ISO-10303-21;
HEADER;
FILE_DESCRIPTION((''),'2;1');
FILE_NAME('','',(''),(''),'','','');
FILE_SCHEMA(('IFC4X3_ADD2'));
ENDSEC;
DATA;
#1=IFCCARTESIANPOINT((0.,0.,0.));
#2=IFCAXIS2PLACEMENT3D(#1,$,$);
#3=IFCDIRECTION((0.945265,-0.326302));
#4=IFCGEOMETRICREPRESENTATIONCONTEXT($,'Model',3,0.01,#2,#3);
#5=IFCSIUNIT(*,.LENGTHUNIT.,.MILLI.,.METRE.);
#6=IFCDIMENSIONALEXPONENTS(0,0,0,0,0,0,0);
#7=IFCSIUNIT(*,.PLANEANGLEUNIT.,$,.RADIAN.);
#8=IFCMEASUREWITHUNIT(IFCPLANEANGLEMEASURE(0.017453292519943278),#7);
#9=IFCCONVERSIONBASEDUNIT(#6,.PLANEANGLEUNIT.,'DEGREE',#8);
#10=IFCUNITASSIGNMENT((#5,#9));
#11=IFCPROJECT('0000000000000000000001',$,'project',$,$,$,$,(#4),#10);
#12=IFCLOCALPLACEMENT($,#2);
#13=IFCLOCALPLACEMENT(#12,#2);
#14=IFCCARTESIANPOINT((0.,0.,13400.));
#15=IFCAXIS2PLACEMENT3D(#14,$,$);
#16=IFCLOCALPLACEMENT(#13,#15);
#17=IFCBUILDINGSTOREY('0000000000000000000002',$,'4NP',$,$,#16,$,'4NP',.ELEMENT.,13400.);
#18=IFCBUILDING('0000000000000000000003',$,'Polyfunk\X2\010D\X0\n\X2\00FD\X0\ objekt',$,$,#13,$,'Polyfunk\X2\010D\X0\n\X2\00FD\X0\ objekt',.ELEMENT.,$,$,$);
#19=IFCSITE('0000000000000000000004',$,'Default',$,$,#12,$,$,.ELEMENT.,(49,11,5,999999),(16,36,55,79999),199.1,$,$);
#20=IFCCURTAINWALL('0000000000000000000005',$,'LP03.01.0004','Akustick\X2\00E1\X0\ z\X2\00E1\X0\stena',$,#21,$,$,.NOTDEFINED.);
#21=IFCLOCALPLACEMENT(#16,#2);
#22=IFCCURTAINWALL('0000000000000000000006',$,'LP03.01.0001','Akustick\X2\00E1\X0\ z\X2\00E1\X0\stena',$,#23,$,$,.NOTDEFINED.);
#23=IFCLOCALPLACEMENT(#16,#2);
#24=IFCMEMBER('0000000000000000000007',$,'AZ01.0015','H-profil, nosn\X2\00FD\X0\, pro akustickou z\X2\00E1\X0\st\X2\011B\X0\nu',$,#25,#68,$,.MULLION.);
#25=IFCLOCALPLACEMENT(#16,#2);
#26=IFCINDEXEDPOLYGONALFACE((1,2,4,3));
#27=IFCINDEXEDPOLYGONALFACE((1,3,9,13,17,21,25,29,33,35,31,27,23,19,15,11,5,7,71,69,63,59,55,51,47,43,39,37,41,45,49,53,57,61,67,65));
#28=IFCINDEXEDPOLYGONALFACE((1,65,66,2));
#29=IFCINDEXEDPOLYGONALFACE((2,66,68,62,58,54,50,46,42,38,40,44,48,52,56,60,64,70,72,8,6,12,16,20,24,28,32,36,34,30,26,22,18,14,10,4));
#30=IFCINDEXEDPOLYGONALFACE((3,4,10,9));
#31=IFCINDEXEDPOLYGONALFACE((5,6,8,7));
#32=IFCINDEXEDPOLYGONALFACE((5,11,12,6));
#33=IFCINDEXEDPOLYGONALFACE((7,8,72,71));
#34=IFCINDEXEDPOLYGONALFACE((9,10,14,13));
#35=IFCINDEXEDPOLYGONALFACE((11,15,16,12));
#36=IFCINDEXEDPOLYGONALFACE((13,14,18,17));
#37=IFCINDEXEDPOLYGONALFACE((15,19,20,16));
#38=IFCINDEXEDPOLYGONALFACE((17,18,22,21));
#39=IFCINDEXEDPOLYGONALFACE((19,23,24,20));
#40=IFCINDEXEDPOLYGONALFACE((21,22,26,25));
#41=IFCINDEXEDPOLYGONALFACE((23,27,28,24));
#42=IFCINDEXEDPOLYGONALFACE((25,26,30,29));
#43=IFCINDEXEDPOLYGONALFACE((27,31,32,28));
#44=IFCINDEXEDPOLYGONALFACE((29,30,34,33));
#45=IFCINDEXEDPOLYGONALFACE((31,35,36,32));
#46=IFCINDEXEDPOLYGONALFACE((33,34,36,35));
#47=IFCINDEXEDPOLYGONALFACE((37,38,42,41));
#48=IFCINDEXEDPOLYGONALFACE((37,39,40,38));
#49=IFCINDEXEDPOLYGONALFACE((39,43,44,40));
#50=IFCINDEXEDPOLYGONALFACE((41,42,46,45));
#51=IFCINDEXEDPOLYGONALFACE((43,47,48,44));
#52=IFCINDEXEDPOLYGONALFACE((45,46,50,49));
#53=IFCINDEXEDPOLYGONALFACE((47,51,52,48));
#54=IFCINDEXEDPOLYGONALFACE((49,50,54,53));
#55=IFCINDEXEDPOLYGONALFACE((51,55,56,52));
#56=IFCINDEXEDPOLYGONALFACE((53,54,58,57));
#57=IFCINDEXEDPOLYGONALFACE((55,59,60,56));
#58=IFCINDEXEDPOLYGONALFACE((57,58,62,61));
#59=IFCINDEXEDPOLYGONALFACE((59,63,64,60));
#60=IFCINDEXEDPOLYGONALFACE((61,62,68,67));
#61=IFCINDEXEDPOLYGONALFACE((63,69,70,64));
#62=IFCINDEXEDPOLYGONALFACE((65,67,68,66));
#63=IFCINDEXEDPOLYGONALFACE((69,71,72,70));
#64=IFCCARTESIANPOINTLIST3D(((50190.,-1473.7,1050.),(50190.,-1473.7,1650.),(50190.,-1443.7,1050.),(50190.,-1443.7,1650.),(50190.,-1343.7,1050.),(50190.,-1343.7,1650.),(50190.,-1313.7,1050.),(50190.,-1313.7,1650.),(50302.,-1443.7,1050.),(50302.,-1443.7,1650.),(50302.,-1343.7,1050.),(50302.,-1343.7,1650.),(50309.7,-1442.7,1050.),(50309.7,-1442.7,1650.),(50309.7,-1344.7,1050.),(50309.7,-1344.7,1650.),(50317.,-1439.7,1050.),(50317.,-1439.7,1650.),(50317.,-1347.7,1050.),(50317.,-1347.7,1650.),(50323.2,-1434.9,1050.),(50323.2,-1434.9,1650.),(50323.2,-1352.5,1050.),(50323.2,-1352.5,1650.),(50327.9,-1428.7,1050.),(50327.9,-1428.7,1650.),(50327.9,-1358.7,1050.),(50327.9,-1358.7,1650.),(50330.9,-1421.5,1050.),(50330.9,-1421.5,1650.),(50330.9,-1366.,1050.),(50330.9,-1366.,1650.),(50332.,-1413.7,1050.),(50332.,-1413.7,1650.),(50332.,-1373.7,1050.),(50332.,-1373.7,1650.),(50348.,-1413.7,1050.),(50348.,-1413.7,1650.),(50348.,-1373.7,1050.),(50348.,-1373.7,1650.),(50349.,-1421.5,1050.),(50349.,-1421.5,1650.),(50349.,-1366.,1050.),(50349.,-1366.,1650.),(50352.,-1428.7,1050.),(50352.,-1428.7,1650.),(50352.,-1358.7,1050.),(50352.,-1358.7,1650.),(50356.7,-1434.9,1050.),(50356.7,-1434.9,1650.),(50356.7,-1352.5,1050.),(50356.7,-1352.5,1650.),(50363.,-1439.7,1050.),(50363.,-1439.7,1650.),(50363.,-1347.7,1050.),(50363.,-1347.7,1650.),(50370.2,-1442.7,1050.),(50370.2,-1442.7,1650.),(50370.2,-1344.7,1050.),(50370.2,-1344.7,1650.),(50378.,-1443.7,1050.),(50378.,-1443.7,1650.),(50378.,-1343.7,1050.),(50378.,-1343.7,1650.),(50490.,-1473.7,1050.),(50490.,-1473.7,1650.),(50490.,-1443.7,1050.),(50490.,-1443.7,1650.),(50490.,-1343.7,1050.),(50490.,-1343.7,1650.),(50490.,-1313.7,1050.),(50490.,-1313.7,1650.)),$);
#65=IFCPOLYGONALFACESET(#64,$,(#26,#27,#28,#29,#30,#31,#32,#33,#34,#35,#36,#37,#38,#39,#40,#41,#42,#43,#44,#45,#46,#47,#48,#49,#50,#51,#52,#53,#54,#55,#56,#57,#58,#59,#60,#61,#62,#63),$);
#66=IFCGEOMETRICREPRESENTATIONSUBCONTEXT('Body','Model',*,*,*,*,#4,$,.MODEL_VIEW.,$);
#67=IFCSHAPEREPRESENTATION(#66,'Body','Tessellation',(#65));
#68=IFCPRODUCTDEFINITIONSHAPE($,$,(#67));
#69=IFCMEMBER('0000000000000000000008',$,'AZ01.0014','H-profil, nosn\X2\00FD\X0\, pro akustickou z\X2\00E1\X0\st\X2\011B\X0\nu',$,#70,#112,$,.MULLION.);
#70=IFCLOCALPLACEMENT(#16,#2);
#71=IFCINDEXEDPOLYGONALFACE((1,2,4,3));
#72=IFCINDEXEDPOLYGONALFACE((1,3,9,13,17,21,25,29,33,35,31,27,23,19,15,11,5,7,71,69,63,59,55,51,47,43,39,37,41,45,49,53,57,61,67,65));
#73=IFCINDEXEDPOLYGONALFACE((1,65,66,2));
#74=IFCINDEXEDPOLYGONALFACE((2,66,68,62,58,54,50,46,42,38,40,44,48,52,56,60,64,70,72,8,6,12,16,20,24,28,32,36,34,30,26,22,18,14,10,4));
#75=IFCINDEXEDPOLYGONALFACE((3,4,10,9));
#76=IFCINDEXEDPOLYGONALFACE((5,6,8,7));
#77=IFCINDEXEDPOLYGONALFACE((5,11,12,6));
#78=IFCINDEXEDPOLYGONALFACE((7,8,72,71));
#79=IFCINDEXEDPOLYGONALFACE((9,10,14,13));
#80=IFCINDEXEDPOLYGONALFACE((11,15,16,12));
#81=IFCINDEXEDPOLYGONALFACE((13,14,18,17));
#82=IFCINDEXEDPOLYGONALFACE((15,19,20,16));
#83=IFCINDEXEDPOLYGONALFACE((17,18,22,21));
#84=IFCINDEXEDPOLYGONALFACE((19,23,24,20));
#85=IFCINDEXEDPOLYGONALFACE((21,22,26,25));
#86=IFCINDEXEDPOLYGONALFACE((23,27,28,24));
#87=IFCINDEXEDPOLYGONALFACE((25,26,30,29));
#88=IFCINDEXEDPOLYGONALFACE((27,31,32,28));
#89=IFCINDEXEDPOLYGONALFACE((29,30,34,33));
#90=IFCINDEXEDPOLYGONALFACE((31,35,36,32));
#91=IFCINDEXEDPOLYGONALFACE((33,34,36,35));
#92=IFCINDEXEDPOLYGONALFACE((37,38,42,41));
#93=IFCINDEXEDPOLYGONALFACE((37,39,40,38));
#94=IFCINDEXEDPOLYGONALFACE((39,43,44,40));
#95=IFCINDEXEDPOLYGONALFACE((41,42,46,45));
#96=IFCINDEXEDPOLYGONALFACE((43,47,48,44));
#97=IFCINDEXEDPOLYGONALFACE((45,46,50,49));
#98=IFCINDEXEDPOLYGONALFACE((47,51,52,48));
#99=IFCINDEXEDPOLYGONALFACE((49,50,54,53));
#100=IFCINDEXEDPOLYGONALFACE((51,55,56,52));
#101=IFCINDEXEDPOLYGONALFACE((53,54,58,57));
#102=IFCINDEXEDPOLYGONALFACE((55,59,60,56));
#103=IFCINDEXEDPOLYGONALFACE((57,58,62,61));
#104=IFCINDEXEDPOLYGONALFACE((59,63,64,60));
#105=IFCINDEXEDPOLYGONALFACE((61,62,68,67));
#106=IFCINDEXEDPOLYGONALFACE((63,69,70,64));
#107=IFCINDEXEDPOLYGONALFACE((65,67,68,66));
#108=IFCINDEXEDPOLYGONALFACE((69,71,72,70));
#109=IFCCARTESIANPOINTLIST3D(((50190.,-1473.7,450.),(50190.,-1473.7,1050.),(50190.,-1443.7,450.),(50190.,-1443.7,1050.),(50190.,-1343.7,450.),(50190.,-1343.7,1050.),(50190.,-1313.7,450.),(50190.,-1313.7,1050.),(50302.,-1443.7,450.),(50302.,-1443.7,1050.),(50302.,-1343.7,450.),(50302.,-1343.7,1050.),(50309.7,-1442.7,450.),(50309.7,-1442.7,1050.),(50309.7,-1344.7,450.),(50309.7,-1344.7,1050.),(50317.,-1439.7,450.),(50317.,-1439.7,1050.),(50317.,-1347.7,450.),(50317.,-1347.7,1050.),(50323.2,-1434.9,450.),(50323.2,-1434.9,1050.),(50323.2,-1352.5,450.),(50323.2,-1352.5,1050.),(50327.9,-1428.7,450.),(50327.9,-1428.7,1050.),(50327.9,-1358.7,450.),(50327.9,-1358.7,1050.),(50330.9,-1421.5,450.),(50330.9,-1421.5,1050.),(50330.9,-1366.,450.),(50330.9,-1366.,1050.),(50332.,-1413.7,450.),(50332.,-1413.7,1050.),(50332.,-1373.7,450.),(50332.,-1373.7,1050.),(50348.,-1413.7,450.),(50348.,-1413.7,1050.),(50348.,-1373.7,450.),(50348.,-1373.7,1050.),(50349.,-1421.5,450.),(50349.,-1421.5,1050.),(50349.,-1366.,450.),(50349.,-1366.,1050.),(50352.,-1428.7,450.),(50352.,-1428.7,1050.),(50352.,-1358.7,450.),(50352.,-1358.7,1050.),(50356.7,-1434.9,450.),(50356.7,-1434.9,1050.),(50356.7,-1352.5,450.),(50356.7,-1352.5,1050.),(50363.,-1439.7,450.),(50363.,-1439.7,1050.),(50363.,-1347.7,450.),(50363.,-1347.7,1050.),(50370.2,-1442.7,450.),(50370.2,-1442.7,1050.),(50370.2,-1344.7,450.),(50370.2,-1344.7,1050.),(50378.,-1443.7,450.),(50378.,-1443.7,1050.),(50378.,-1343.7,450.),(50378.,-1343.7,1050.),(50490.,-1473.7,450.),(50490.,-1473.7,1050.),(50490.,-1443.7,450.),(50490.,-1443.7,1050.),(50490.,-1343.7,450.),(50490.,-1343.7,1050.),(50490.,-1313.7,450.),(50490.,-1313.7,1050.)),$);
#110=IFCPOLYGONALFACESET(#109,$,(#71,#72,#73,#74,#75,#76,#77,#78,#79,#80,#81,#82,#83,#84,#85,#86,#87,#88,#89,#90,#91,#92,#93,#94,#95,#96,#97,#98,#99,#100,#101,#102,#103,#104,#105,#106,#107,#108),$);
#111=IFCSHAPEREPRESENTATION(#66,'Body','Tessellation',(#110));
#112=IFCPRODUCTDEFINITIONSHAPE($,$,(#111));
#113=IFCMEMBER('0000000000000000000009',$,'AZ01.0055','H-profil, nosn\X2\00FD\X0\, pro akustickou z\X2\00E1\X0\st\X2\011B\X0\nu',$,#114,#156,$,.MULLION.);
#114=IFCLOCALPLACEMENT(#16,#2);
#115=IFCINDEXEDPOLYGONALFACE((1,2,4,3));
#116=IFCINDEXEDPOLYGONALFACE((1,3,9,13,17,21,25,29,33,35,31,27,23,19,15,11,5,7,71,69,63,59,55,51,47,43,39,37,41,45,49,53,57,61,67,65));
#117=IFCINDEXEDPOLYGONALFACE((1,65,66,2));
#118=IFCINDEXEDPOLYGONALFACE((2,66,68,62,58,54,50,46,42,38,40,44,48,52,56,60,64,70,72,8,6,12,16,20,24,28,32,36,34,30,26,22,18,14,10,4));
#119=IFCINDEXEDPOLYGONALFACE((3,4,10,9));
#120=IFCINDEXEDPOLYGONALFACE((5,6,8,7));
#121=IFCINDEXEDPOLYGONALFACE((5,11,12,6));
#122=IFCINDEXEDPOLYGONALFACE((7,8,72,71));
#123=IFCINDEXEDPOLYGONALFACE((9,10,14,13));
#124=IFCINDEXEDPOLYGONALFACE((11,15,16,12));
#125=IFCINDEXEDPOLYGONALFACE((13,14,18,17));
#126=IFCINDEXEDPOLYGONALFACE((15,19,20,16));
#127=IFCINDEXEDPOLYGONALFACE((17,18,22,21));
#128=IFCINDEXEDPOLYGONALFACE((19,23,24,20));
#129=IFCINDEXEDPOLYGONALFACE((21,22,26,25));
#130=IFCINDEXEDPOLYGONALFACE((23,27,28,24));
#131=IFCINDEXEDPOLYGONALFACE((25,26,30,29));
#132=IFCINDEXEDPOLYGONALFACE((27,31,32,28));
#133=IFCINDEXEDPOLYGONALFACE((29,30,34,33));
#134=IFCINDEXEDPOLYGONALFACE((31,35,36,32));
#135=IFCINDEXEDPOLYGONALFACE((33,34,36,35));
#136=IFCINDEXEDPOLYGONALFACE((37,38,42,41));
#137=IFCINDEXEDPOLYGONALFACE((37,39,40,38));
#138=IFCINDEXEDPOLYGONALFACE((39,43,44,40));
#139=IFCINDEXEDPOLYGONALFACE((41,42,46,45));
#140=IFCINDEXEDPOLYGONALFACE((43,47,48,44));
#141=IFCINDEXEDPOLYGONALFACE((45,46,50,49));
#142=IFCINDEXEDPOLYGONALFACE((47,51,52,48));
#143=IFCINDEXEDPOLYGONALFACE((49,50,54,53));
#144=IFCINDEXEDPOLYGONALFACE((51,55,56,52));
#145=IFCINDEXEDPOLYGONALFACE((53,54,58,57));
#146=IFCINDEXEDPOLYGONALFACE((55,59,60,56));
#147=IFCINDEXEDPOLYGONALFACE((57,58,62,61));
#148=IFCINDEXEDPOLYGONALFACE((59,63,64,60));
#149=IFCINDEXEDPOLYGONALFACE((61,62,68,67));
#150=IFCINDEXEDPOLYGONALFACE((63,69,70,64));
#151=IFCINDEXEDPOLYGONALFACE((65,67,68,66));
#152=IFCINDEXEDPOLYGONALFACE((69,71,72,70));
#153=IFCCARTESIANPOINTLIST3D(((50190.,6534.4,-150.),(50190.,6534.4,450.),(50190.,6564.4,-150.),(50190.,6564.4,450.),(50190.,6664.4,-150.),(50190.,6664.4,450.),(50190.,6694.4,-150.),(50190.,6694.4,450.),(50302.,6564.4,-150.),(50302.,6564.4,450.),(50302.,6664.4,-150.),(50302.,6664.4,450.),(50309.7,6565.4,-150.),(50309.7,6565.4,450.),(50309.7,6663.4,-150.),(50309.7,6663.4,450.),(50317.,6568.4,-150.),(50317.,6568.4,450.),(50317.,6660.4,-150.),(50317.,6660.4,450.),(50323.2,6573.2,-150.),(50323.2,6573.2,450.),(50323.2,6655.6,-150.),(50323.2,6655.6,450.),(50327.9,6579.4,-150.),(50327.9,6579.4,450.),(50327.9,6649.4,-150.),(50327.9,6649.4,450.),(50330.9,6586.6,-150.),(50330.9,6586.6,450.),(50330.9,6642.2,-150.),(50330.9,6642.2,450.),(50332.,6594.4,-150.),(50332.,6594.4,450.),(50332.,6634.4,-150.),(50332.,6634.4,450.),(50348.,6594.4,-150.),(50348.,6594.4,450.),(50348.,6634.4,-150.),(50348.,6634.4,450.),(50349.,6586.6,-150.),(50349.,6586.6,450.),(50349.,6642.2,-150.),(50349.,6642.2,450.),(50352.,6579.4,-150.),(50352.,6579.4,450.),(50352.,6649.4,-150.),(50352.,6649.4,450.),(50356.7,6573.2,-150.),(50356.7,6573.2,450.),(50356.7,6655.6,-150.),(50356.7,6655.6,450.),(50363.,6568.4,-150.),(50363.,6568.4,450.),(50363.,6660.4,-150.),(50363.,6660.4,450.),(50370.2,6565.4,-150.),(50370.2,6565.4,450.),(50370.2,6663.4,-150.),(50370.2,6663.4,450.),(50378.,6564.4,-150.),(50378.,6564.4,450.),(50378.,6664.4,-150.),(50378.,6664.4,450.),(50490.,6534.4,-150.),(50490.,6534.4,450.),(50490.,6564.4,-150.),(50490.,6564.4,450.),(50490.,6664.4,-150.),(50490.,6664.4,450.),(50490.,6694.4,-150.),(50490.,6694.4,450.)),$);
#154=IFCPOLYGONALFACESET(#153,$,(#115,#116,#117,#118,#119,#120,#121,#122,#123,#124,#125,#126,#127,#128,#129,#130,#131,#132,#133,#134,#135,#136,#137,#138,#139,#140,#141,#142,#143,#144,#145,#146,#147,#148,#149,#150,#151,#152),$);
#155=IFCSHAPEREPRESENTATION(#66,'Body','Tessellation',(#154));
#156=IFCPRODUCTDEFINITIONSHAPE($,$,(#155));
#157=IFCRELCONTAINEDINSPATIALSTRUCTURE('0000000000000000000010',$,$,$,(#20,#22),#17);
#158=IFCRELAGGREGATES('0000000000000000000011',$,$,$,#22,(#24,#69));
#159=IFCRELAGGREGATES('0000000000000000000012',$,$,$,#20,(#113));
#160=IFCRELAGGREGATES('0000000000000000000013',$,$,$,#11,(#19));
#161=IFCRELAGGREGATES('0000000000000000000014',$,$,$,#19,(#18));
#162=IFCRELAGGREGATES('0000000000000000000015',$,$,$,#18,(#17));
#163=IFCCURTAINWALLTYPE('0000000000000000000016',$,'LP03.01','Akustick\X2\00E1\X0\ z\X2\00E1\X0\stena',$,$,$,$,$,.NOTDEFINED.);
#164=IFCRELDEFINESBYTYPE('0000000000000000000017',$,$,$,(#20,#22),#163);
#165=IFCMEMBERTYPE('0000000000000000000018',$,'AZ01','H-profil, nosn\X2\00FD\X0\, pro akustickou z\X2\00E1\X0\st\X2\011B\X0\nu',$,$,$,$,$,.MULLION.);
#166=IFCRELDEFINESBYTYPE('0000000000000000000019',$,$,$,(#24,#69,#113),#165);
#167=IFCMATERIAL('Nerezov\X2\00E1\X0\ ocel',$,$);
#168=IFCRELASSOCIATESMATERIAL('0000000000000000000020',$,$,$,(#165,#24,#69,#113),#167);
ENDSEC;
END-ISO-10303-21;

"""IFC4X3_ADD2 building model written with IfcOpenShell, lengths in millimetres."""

from ifc_helpers import new_model, entity, si_unit, converted_unit, direction, frame, frame_2d, origin, place, context, subcontext, project, spatial, polyline, circle_curve, parameter, trimmed, segment, composite_curve, outline, extrude, source, transform, mapped, material, material_profile, profile_set, profile_usage, type_object, element, aggregate, save


model = new_model("IFC4X3_ADD2")

# Units and contexts
model_context = context("Model", 3, precision=0.01, world=origin(), true_north=direction((0.945265, -0.326302)))
body_context = subcontext(model_context, "Body", "Model", "MODEL_VIEW")
ifc_project = project(units=[si_unit("LENGTHUNIT", "METRE", prefix="MILLI"), converted_unit("PLANEANGLEUNIT", "DEGREE", entity("IfcPlaneAngleMeasure", 0.017453292519943278), si_unit("PLANEANGLEUNIT", "RADIAN"), dimensions=[0, 0, 0, 0, 0, 0, 0])], contexts=[model_context])

# Site, building, storey
site_placement = place(None, origin())
site = spatial("IfcSite", under=ifc_project, at=site_placement, Name="Default", CompositionType="ELEMENT", RefLatitude=(49, 11, 5, 999999), RefLongitude=(16, 36, 55, 79999), RefElevation=199.1)
building_placement = place(site_placement, origin())
building = spatial("IfcBuilding", under=site, at=building_placement, Name="Polyfunkčný objekt", LongName="Polyfunkčný objekt", CompositionType="ELEMENT")
storey_placement = place(building_placement, frame((0.0, 0.0, 13400.0)))
storey = spatial("IfcBuildingStorey", under=building, at=storey_placement, Name="4NP", LongName="4NP", CompositionType="ELEMENT", Elevation=13400.0)

# Curtain walls, members
curtain_wall_type = type_object("IfcCurtainWallType", Name="LP03.01", Description="Akustická zástena", PredefinedType="NOTDEFINED")
curtain_wall_1_placement = place(storey_placement, frame((0.0, 0.0, -13400.0)))
curtain_wall_1 = element("IfcCurtainWall", 1, at=curtain_wall_1_placement, inside=storey, type_object=curtain_wall_type, Name="LP03.01.0004", Description="Akustická zástena", PredefinedType="NOTDEFINED")
ifc_material_1 = material(Name="Nerezová ocel")
ifc_material_profile = material_profile(ifc_material_1, outline(composite_curve([segment(polyline([(50.0, -150.0), (80.0, -150.0)]), True, "CONTINUOUS"), segment(polyline([(80.0, -150.0), (80.0, 150.0)]), True, "CONTINUOUS"), segment(polyline([(80.0, 150.0), (50.0, 150.0)]), True, "CONTINUOUS"), segment(polyline([(50.0, 150.0), (50.0, 38.0)]), True, "CONTINUOUS"), segment(trimmed(circle_curve(frame_2d((20.0, 38.0), x_axis=(0.0, 1.0)), 30.0), [parameter(180.0)], [parameter(270.0)], True, "PARAMETER"), False, "CONTINUOUS"), segment(polyline([(20.0, 8.0), (-20.0, 8.0)]), True, "CONTINUOUS"), segment(trimmed(circle_curve(frame_2d((-20.0, 38.0), x_axis=(0.0, 1.0)), 30.0), [parameter(90.0)], [parameter(180.0)], True, "PARAMETER"), False, "CONTINUOUS"), segment(polyline([(-50.0, 38.0), (-50.0, 150.0)]), True, "CONTINUOUS"), segment(polyline([(-50.0, 150.0), (-80.0, 150.0)]), True, "CONTINUOUS"), segment(polyline([(-80.0, 150.0), (-80.0, -150.0)]), True, "CONTINUOUS"), segment(polyline([(-80.0, -150.0), (-50.0, -150.0)]), True, "CONTINUOUS"), segment(polyline([(-50.0, -150.0), (-50.0, -38.0)]), True, "CONTINUOUS"), segment(trimmed(circle_curve(frame_2d((-20.0, -38.0), x_axis=(0.0, 1.0)), 30.0), [parameter(0.0)], [parameter(90.0)], True, "PARAMETER"), False, "CONTINUOUS"), segment(polyline([(-20.0, -8.0), (20.0, -8.0)]), True, "CONTINUOUS"), segment(trimmed(circle_curve(frame_2d((20.0, -38.0), x_axis=(0.0, 1.0)), 30.0), [parameter(270.0)], [parameter(0.0)], True, "PARAMETER"), False, "CONTINUOUS"), segment(polyline([(50.0, -38.0), (50.0, -150.0)]), True, "CONTINUOUS")], self_intersect=False)), Name="Profil zástena")
ifc_profile_set = profile_set([ifc_material_profile], Name="Profil zástena")
ifc_profile_usage = profile_usage(ifc_profile_set)
member_type = type_object("IfcMemberType", Name="AZ01", Description="H-profil, nosný, pro akustickou zástěnu", PredefinedType="MULLION", material=ifc_profile_set)
shared_shape_1 = source(origin(), body_context, "Body", "SweptSolid", [
    extrude(outline(composite_curve([segment(polyline([(-150.0, -50.0), (-150.0, -80.0)]), True, "CONTINUOUS"), segment(polyline([(-150.0, -80.0), (150.0, -80.0)]), True, "CONTINUOUS"), segment(polyline([(150.0, -80.0), (150.0, -50.0)]), True, "CONTINUOUS"), segment(polyline([(150.0, -50.0), (38.0, -50.0)]), True, "CONTINUOUS"), segment(trimmed(circle_curve(frame_2d((38.0, -20.0), x_axis=(1.0, 0.0)), 30.0), [parameter(180.0)], [parameter(270.0)], True, "PARAMETER"), False, "CONTINUOUS"), segment(polyline([(8.0, -20.0), (8.0, 20.0)]), True, "CONTINUOUS"), segment(trimmed(circle_curve(frame_2d((38.0, 20.0), x_axis=(1.0, 0.0)), 30.0), [parameter(90.0)], [parameter(180.0)], True, "PARAMETER"), False, "CONTINUOUS"), segment(polyline([(38.0, 50.0), (150.0, 50.0)]), True, "CONTINUOUS"), segment(polyline([(150.0, 50.0), (150.0, 80.0)]), True, "CONTINUOUS"), segment(polyline([(150.0, 80.0), (-150.0, 80.0)]), True, "CONTINUOUS"), segment(polyline([(-150.0, 80.0), (-150.0, 50.0)]), True, "CONTINUOUS"), segment(polyline([(-150.0, 50.0), (-38.0, 50.0)]), True, "CONTINUOUS"), segment(trimmed(circle_curve(frame_2d((-38.0, 20.0), x_axis=(1.0, 0.0)), 30.0), [parameter(0.0)], [parameter(90.0)], True, "PARAMETER"), False, "CONTINUOUS"), segment(polyline([(-8.0, 20.0), (-8.0, -20.0)]), True, "CONTINUOUS"), segment(trimmed(circle_curve(frame_2d((-38.0, -20.0), x_axis=(1.0, 0.0)), 30.0), [parameter(270.0)], [parameter(0.0)], True, "PARAMETER"), False, "CONTINUOUS"), segment(polyline([(-38.0, -50.0), (-150.0, -50.0)]), True, "CONTINUOUS")], self_intersect=False)), frame((-150.0, 0.0, -600.0), z_axis=(0.0, 0.0, -1.0), x_axis=(-1.0, 0.0, 0.0)), (0.0, 0.0, -1.0), 600.0),
])
curtain_wall_2_placement = place(storey_placement, frame((0.0, 0.0, -13400.0)))
curtain_wall_2 = element("IfcCurtainWall", 2, at=curtain_wall_2_placement, inside=storey, type_object=curtain_wall_type, Name="LP03.01.0001", Description="Akustická zástena", PredefinedType="NOTDEFINED")
member_1_placement = place(curtain_wall_2_placement, frame((50190.0, -1393.7, 15050.0), z_axis=(0.0, 0.0, 1.0), x_axis=(-1.0, 0.0, 0.0)))
member_1 = element("IfcMember", 3, at=member_1_placement, type_object=member_type, material=ifc_profile_usage, Name="AZ01.0015", Description="H-profil, nosný, pro akustickou zástěnu", PredefinedType="MULLION", context=body_context, shape_type="MappedRepresentation", body=[
    mapped(shared_shape_1, transform((0.0, 0.0, 0.0), scale=1.0)),
])
member_2_placement = place(curtain_wall_2_placement, frame((50190.0, -1393.7, 14450.0), z_axis=(0.0, 0.0, 1.0), x_axis=(-1.0, 0.0, 0.0)))
member_2 = element("IfcMember", 4, at=member_2_placement, type_object=member_type, material=ifc_profile_usage, Name="AZ01.0014", Description="H-profil, nosný, pro akustickou zástěnu", PredefinedType="MULLION", context=body_context, shape_type="MappedRepresentation", body=[
    mapped(shared_shape_1, transform((0.0, 0.0, 0.0), scale=1.0)),
])

# Member
shared_shape_2 = source(origin(), body_context, "Body", "SweptSolid", [
    extrude(outline(composite_curve([segment(polyline([(-150.0, -50.0), (-150.0, -80.0)]), True, "CONTINUOUS"), segment(polyline([(-150.0, -80.0), (150.0, -80.0)]), True, "CONTINUOUS"), segment(polyline([(150.0, -80.0), (150.0, -50.0)]), True, "CONTINUOUS"), segment(polyline([(150.0, -50.0), (38.0, -50.0)]), True, "CONTINUOUS"), segment(trimmed(circle_curve(frame_2d((38.0, -20.0), x_axis=(1.0, 0.0)), 30.0), [parameter(180.0)], [parameter(270.0)], True, "PARAMETER"), False, "CONTINUOUS"), segment(polyline([(8.0, -20.0), (8.0, 20.0)]), True, "CONTINUOUS"), segment(trimmed(circle_curve(frame_2d((38.0, 20.0), x_axis=(1.0, 0.0)), 30.0), [parameter(90.0)], [parameter(180.0)], True, "PARAMETER"), False, "CONTINUOUS"), segment(polyline([(38.0, 50.0), (150.0, 50.0)]), True, "CONTINUOUS"), segment(polyline([(150.0, 50.0), (150.0, 80.0)]), True, "CONTINUOUS"), segment(polyline([(150.0, 80.0), (-150.0, 80.0)]), True, "CONTINUOUS"), segment(polyline([(-150.0, 80.0), (-150.0, 50.0)]), True, "CONTINUOUS"), segment(polyline([(-150.0, 50.0), (-38.0, 50.0)]), True, "CONTINUOUS"), segment(trimmed(circle_curve(frame_2d((-38.0, 20.0), x_axis=(1.0, 0.0)), 30.0), [parameter(0.0)], [parameter(90.0)], True, "PARAMETER"), False, "CONTINUOUS"), segment(polyline([(-8.0, 20.0), (-8.0, -20.0)]), True, "CONTINUOUS"), segment(trimmed(circle_curve(frame_2d((-38.0, -20.0), x_axis=(1.0, 0.0)), 30.0), [parameter(270.0)], [parameter(0.0)], True, "PARAMETER"), False, "CONTINUOUS"), segment(polyline([(-38.0, -50.0), (-150.0, -50.0)]), True, "CONTINUOUS")], self_intersect=False)), frame((-150.0, 0.0, -600.0), z_axis=(0.0, 0.0, -1.0), x_axis=(-1.0, 0.0, 0.0)), (0.0, 0.0, -1.0), 600.0),
])
member_3_placement = place(curtain_wall_1_placement, frame((50190.0, 6614.4, 13850.0), z_axis=(0.0, 0.0, 1.0), x_axis=(-1.0, 0.0, 0.0)))
member_3 = element("IfcMember", 5, at=member_3_placement, type_object=member_type, material=ifc_profile_usage, Name="AZ01.0055", Description="H-profil, nosný, pro akustickou zástěnu", PredefinedType="MULLION", context=body_context, shape_type="MappedRepresentation", body=[
    mapped(shared_shape_2, transform((0.0, 0.0, 0.0), scale=1.0)),
])
aggregate(curtain_wall_2, [member_1, member_2])

aggregate(curtain_wall_1, [member_3])

save(model, "model.ifc")
